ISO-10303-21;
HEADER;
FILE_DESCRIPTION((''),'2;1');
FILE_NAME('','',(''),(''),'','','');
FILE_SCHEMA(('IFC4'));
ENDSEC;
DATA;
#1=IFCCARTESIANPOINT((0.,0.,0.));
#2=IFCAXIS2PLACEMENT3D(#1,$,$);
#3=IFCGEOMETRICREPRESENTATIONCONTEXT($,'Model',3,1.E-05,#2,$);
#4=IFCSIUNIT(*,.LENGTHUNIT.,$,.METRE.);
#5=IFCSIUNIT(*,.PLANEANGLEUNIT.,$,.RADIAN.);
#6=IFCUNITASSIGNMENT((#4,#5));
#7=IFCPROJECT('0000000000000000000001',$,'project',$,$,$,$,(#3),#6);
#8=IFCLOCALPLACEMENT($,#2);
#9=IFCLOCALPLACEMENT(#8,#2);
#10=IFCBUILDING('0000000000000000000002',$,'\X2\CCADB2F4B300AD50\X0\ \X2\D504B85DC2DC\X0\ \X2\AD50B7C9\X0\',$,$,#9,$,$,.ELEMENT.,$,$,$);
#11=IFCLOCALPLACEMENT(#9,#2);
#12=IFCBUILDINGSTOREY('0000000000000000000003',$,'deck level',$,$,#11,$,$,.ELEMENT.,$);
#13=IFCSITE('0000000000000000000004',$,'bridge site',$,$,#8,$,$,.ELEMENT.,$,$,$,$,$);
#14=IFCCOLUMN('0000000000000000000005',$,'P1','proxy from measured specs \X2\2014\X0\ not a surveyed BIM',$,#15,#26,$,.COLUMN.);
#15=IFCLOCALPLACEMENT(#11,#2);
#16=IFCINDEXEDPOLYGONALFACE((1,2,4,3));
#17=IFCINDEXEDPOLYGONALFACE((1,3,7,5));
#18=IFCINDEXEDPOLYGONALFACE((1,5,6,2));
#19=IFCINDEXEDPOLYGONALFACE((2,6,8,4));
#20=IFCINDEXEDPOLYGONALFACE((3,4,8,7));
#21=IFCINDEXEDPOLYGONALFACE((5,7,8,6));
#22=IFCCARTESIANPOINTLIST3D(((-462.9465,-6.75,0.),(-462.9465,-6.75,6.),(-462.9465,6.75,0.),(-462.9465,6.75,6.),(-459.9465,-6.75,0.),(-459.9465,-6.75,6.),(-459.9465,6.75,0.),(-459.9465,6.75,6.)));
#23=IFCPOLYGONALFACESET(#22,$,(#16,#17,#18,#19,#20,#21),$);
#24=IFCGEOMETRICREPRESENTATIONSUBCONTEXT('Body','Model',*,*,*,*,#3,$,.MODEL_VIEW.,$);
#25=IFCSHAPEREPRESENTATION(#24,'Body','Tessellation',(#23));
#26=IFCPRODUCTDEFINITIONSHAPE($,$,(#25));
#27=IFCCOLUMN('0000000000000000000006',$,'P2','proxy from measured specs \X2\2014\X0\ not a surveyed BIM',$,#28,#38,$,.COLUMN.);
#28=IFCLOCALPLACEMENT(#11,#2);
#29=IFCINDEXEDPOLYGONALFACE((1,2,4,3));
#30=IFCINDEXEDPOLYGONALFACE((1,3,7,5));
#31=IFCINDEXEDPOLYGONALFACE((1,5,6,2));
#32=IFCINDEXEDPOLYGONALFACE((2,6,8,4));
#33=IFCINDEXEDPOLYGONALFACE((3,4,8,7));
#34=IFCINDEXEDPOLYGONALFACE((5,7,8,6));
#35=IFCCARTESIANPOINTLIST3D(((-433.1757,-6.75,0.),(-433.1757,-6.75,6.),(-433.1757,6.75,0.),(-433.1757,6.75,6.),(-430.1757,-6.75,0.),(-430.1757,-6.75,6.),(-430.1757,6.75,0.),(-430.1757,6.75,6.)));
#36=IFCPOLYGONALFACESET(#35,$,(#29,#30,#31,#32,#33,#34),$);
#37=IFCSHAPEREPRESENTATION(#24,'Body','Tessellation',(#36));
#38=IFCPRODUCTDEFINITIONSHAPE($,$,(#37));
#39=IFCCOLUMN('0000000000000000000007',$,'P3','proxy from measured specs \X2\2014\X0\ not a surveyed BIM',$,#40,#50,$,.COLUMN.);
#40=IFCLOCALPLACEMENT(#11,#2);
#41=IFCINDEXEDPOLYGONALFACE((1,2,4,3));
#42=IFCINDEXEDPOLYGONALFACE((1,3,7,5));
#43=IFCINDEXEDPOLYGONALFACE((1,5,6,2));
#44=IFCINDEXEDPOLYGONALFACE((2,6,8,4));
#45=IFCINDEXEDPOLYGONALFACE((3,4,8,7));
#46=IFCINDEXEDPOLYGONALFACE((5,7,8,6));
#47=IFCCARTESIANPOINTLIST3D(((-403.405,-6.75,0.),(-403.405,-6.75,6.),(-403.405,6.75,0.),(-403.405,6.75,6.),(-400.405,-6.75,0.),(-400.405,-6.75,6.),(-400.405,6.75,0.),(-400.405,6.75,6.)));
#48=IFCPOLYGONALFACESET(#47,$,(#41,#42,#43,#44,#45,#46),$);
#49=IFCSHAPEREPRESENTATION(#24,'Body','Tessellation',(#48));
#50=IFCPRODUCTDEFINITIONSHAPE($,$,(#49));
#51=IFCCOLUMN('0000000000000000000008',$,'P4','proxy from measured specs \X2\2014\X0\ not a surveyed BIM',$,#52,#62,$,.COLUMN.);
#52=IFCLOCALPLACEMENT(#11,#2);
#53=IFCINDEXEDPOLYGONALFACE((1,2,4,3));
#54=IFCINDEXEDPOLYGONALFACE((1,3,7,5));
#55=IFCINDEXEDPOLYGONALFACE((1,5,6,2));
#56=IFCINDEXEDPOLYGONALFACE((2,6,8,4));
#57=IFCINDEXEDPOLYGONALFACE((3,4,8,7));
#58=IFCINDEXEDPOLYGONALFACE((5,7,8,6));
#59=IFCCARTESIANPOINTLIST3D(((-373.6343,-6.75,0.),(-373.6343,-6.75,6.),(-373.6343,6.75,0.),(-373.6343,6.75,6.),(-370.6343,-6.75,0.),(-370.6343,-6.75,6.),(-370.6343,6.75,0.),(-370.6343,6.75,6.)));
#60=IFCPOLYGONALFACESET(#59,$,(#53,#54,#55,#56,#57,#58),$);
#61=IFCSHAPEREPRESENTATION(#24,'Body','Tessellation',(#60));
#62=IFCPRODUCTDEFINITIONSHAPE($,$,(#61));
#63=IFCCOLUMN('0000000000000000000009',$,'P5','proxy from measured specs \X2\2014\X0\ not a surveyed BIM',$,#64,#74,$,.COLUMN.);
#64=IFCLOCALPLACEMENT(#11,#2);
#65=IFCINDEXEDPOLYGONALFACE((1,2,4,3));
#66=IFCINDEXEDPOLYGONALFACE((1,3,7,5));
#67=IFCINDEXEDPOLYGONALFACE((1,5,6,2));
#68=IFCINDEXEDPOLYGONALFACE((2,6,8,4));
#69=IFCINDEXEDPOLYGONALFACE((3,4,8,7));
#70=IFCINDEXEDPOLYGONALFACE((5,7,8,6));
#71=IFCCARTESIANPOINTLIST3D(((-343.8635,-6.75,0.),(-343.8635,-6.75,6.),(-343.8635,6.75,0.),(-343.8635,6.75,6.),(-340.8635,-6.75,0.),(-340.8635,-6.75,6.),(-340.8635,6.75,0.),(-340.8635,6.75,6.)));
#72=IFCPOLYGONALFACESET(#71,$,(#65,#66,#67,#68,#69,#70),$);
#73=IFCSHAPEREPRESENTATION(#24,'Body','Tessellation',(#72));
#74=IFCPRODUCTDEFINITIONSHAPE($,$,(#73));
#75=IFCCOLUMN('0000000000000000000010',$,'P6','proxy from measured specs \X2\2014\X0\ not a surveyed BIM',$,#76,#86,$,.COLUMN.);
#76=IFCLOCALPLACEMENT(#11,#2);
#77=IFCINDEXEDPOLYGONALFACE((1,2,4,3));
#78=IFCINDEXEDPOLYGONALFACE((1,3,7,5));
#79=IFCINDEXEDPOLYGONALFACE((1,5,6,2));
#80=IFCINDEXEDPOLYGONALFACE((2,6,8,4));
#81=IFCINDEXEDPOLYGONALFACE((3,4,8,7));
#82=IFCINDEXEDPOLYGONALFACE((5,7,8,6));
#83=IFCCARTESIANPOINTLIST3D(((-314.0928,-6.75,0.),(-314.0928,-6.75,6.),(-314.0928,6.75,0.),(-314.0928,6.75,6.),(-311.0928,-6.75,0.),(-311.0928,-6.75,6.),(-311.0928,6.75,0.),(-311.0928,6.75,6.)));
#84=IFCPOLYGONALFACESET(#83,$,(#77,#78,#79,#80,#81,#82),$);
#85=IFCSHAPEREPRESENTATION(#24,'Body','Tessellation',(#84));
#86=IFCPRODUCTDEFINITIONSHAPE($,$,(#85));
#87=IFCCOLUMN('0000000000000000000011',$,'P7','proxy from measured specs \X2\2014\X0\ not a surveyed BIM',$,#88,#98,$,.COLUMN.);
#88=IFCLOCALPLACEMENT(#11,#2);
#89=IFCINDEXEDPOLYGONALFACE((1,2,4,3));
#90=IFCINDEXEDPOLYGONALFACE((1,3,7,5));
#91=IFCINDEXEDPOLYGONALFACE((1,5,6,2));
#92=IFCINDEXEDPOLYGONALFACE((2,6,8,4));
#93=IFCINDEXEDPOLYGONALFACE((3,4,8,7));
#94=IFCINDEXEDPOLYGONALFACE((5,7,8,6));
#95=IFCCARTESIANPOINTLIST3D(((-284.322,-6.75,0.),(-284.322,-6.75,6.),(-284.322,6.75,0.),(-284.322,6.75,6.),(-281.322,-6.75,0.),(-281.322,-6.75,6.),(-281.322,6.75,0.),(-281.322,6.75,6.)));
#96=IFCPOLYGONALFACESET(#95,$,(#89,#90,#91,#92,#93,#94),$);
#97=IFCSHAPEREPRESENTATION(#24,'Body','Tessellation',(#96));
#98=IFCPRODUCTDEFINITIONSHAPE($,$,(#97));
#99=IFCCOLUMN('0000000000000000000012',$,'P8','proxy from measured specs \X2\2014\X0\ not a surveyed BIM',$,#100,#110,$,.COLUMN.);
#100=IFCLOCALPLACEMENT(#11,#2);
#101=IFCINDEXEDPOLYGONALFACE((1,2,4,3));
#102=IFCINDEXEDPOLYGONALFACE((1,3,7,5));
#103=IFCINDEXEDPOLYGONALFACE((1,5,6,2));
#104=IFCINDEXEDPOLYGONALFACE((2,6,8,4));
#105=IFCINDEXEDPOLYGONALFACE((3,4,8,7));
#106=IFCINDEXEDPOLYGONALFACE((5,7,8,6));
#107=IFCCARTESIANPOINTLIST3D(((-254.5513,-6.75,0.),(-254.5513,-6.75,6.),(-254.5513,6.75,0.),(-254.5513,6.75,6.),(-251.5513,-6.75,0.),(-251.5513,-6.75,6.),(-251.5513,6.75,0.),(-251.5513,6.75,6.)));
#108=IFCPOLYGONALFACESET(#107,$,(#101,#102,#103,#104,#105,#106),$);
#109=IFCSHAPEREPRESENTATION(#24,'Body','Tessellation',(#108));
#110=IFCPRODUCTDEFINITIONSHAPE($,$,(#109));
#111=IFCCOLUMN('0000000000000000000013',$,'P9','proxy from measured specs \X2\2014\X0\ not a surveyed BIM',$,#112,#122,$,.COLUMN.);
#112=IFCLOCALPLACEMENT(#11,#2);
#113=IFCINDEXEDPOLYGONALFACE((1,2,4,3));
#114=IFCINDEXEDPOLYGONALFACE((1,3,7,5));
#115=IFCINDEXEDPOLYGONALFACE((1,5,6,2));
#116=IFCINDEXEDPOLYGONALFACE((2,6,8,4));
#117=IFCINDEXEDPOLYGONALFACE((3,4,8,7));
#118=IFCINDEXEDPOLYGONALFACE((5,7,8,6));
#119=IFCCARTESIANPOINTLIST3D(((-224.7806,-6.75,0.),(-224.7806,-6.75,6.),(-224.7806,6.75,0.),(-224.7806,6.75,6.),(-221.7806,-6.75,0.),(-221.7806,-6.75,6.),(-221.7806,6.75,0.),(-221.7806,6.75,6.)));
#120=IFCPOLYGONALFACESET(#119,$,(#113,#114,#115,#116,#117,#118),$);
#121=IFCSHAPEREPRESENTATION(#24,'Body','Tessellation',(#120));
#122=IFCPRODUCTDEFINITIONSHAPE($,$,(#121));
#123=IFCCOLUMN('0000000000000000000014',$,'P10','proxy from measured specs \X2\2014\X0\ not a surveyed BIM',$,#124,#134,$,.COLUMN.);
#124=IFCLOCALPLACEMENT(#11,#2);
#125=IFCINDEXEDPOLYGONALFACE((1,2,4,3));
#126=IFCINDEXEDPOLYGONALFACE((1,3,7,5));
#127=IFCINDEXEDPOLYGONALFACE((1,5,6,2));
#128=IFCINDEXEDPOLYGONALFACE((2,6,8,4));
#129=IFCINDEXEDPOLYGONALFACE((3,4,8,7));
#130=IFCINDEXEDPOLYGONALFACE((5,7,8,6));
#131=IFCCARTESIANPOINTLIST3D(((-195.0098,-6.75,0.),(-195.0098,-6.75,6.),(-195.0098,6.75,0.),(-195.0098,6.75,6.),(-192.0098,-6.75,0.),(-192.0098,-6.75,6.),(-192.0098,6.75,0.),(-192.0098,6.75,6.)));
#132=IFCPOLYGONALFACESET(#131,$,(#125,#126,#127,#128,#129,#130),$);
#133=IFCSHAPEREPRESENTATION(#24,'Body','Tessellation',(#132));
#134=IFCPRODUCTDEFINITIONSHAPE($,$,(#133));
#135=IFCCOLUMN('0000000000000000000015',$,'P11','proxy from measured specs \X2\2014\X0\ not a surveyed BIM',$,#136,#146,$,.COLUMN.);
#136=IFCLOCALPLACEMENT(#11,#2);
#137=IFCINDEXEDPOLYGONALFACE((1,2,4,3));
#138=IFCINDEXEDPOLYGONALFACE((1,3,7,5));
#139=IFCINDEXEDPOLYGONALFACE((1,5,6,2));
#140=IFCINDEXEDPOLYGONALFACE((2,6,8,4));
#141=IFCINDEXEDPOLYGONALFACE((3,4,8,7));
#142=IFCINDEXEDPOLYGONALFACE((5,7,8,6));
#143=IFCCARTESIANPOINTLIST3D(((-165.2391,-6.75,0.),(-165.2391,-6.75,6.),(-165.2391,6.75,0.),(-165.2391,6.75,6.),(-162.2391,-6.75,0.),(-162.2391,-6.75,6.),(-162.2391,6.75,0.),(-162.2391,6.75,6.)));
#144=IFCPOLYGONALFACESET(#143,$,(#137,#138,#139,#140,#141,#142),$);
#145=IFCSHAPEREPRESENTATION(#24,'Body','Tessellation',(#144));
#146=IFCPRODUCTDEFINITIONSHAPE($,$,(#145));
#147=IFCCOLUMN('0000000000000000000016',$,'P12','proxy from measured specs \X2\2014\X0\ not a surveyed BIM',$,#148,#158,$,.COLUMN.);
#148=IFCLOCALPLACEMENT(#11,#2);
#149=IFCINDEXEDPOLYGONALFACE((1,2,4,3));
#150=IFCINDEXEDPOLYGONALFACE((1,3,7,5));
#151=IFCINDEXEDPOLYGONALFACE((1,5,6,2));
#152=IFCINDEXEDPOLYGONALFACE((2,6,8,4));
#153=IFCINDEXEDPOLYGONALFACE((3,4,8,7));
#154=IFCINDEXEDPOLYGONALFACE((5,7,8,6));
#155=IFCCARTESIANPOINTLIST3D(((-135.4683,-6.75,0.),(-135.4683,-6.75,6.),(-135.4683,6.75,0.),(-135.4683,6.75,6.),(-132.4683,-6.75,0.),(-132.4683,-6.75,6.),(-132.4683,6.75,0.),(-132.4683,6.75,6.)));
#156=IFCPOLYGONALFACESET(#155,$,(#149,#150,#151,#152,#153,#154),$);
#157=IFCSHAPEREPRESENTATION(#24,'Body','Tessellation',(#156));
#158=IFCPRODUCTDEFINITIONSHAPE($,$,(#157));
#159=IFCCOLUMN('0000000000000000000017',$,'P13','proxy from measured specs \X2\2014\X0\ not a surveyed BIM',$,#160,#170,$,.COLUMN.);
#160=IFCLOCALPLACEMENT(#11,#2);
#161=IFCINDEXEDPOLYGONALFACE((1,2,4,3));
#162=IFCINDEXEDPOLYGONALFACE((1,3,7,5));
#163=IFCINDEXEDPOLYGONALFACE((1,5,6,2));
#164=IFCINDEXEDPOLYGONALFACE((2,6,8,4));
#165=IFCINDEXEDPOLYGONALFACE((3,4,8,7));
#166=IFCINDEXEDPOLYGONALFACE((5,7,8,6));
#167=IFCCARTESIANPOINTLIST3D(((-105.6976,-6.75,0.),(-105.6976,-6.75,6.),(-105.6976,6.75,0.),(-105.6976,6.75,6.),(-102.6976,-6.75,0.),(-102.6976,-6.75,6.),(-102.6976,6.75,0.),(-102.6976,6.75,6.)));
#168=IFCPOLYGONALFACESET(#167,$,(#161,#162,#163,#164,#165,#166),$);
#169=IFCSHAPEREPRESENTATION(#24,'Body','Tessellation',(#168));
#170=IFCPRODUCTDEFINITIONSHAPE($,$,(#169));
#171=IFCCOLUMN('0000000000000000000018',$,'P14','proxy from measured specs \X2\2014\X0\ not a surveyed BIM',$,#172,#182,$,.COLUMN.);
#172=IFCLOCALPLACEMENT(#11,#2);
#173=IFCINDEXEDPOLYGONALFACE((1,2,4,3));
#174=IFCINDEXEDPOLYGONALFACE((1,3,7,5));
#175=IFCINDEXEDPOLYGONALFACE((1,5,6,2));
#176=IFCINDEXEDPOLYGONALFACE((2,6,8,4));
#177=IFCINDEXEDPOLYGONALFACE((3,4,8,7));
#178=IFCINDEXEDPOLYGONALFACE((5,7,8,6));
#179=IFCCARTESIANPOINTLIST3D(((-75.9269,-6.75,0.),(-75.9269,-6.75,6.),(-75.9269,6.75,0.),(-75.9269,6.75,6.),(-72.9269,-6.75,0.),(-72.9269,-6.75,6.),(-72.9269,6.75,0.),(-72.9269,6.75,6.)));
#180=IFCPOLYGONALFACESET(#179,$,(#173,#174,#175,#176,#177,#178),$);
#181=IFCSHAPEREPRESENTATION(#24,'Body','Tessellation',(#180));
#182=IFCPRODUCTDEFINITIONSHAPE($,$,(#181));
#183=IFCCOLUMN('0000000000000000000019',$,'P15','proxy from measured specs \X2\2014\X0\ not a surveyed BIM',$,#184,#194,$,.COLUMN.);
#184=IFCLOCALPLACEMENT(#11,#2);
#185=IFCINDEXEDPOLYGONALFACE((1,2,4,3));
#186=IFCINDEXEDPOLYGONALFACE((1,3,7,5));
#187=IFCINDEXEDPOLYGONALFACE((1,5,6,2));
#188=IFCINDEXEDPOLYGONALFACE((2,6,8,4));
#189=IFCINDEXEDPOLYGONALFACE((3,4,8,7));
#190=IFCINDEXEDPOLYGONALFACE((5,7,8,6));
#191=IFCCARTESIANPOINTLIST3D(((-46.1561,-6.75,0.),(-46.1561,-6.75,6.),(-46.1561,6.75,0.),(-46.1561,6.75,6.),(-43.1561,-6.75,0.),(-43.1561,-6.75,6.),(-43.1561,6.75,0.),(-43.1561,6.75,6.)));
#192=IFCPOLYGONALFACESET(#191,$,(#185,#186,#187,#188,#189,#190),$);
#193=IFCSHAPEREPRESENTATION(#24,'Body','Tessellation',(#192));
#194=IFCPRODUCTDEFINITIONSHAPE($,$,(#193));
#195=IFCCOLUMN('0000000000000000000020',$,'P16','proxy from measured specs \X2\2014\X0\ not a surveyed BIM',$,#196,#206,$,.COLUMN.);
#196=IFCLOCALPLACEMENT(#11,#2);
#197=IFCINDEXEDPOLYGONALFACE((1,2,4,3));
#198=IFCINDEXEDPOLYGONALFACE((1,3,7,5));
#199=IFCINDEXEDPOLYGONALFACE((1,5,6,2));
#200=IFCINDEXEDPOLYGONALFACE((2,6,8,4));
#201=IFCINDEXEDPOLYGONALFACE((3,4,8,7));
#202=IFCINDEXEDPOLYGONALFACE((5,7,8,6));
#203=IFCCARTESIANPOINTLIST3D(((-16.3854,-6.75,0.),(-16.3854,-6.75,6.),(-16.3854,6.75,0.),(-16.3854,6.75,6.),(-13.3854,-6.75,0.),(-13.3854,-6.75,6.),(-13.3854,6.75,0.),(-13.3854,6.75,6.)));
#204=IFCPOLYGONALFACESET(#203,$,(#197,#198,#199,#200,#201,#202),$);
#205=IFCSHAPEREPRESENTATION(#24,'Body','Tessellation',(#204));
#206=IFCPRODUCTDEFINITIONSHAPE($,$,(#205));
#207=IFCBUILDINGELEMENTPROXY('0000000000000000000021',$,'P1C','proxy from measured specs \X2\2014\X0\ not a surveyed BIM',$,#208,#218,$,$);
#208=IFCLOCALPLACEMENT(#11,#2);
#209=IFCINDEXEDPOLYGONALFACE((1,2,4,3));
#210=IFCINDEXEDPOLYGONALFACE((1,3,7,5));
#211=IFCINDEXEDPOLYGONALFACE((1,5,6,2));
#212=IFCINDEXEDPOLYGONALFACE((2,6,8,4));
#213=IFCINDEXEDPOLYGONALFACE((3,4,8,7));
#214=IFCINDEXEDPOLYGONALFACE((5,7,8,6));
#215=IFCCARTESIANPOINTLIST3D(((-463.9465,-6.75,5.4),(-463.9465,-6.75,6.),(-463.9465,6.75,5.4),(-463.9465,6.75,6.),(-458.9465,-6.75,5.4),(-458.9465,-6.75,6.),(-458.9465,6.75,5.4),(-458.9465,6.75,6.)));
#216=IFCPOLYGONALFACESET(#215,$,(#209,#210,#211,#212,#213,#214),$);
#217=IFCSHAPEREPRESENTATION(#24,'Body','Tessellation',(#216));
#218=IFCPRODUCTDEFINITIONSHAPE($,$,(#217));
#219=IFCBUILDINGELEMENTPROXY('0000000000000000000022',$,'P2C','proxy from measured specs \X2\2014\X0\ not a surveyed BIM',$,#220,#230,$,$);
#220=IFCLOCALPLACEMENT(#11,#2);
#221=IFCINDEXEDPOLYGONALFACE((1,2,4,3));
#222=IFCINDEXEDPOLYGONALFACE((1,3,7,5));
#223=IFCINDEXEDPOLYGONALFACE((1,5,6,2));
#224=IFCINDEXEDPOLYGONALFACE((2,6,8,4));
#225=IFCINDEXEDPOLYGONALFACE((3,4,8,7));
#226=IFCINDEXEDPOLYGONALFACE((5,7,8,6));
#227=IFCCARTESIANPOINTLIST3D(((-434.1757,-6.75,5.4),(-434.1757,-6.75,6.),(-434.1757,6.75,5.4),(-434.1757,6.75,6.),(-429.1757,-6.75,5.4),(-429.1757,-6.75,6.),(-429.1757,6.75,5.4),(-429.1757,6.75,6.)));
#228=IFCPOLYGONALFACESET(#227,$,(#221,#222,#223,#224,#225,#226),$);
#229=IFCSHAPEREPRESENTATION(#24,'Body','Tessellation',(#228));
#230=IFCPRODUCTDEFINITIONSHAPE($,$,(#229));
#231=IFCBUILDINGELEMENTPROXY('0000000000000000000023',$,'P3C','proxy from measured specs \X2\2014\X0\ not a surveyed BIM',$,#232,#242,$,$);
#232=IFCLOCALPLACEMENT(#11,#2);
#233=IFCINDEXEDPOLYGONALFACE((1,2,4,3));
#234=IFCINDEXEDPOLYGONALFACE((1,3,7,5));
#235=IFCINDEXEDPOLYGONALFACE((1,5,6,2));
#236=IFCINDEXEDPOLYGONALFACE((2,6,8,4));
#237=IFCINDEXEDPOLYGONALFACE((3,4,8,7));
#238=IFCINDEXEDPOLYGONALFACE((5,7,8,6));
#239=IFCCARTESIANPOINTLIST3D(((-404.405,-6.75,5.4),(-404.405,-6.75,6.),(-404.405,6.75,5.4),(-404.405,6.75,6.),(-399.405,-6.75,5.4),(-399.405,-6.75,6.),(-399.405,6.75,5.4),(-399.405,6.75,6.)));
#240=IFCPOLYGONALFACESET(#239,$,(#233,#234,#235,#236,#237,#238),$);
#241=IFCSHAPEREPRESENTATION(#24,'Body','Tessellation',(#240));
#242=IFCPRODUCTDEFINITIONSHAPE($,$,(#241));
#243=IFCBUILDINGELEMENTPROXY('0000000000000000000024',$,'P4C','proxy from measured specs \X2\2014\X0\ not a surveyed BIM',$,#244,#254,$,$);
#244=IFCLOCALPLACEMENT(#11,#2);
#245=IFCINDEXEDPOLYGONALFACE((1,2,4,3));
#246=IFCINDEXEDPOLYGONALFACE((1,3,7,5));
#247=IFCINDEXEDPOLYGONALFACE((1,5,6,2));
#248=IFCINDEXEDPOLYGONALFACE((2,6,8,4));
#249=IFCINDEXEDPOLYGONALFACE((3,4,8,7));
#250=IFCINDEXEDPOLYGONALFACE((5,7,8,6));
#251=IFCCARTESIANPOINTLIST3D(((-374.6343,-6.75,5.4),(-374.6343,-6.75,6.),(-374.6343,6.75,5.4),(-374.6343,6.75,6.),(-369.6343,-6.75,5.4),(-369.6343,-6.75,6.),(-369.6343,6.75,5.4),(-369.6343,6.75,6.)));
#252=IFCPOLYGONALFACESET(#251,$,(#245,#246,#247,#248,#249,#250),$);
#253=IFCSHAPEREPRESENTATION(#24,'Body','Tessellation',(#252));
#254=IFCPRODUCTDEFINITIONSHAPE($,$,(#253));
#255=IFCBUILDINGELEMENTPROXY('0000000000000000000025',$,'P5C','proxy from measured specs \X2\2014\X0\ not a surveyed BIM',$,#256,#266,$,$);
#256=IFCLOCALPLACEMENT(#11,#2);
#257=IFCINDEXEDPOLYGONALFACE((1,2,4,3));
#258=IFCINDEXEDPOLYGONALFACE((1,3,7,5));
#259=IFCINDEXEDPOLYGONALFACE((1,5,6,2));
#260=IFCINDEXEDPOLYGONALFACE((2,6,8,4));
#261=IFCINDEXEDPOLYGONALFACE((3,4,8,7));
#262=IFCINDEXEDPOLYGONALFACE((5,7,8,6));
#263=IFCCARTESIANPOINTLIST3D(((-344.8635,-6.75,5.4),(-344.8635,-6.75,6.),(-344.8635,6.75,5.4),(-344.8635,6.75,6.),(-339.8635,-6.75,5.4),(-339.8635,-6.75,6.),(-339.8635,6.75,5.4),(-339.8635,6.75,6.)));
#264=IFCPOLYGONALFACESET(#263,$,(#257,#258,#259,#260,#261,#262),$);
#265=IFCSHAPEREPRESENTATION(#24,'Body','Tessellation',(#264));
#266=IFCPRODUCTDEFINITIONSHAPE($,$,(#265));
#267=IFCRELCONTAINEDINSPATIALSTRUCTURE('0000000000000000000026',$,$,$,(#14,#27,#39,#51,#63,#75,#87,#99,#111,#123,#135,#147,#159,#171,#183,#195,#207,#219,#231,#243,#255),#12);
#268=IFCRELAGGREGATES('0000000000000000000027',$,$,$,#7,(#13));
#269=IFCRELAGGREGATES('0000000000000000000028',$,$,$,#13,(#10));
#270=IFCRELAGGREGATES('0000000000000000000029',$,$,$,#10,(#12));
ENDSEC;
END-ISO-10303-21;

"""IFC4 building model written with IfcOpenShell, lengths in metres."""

from ifc_helpers import new_model, si_unit, frame, origin, origin_2d, place, context, subcontext, project, spatial, rectangle, extrude, element, save


model = new_model("IFC4")

# Units and contexts
model_context = context("Model", 3, precision=1e-05, world=origin())
body_context = subcontext(model_context, "Body", "Model", "MODEL_VIEW")
ifc_project = project(units=[si_unit("LENGTHUNIT", "METRE"), si_unit("PLANEANGLEUNIT", "RADIAN")], contexts=[model_context])

# Site, building, storey
site_placement = place(None, origin())
site = spatial("IfcSite", under=ifc_project, at=site_placement, Name="bridge site", CompositionType="ELEMENT")
building_placement = place(site_placement, origin())
building = spatial("IfcBuilding", under=site, at=building_placement, Name="청담대교 프록시 교량", CompositionType="ELEMENT")
storey_placement = place(building_placement, origin())
storey = spatial("IfcBuildingStorey", under=building, at=storey_placement, Name="deck level", CompositionType="ELEMENT")

# Columns
for number, where, name in (
    (1, (-461.4465, 0.0, 0.0), "P1"),
    (2, (-431.6757, 0.0, 0.0), "P2"),
    (3, (-401.905, 0.0, 0.0), "P3"),
    (4, (-372.1343, 0.0, 0.0), "P4"),
    (5, (-342.3635, 0.0, 0.0), "P5"),
    (6, (-312.5928, 0.0, 0.0), "P6"),
    (7, (-282.822, 0.0, 0.0), "P7"),
    (8, (-253.0513, 0.0, 0.0), "P8"),
    (9, (-223.2806, 0.0, 0.0), "P9"),
    (10, (-193.5098, 0.0, 0.0), "P10"),
    (11, (-163.7391, 0.0, 0.0), "P11"),
    (12, (-133.9683, 0.0, 0.0), "P12"),
    (13, (-104.1976, 0.0, 0.0), "P13"),
    (14, (-74.4269, 0.0, 0.0), "P14"),
    (15, (-44.6561, 0.0, 0.0), "P15"),
    (16, (-14.8854, 0.0, 0.0), "P16"),
):
    element("IfcColumn", number, at=place(storey_placement, frame(where)), inside=storey, Name=name, Description="proxy from measured specs — not a surveyed BIM", PredefinedType="COLUMN", context=body_context, shape_type="SweptSolid", body=[
        extrude(rectangle(XDim=3.0, YDim=13.5, at=origin_2d()), origin(), (0.0, 0.0, 1.0), 6.0),
    ])

# Building element proxies
for number, where, name in (
    (17, (-461.4465, 0.0, 5.4), "P1C"),
    (18, (-431.6757, 0.0, 5.4), "P2C"),
    (19, (-401.905, 0.0, 5.4), "P3C"),
    (20, (-372.1343, 0.0, 5.4), "P4C"),
    (21, (-342.3635, 0.0, 5.4), "P5C"),
):
    element("IfcBuildingElementProxy", number, at=place(storey_placement, frame(where)), inside=storey, Name=name, Description="proxy from measured specs — not a surveyed BIM", context=body_context, shape_type="SweptSolid", body=[
        extrude(rectangle(XDim=5.0, YDim=13.5, at=origin_2d()), origin(), (0.0, 0.0, 1.0), 0.6),
    ])

save(model, "model.ifc")
